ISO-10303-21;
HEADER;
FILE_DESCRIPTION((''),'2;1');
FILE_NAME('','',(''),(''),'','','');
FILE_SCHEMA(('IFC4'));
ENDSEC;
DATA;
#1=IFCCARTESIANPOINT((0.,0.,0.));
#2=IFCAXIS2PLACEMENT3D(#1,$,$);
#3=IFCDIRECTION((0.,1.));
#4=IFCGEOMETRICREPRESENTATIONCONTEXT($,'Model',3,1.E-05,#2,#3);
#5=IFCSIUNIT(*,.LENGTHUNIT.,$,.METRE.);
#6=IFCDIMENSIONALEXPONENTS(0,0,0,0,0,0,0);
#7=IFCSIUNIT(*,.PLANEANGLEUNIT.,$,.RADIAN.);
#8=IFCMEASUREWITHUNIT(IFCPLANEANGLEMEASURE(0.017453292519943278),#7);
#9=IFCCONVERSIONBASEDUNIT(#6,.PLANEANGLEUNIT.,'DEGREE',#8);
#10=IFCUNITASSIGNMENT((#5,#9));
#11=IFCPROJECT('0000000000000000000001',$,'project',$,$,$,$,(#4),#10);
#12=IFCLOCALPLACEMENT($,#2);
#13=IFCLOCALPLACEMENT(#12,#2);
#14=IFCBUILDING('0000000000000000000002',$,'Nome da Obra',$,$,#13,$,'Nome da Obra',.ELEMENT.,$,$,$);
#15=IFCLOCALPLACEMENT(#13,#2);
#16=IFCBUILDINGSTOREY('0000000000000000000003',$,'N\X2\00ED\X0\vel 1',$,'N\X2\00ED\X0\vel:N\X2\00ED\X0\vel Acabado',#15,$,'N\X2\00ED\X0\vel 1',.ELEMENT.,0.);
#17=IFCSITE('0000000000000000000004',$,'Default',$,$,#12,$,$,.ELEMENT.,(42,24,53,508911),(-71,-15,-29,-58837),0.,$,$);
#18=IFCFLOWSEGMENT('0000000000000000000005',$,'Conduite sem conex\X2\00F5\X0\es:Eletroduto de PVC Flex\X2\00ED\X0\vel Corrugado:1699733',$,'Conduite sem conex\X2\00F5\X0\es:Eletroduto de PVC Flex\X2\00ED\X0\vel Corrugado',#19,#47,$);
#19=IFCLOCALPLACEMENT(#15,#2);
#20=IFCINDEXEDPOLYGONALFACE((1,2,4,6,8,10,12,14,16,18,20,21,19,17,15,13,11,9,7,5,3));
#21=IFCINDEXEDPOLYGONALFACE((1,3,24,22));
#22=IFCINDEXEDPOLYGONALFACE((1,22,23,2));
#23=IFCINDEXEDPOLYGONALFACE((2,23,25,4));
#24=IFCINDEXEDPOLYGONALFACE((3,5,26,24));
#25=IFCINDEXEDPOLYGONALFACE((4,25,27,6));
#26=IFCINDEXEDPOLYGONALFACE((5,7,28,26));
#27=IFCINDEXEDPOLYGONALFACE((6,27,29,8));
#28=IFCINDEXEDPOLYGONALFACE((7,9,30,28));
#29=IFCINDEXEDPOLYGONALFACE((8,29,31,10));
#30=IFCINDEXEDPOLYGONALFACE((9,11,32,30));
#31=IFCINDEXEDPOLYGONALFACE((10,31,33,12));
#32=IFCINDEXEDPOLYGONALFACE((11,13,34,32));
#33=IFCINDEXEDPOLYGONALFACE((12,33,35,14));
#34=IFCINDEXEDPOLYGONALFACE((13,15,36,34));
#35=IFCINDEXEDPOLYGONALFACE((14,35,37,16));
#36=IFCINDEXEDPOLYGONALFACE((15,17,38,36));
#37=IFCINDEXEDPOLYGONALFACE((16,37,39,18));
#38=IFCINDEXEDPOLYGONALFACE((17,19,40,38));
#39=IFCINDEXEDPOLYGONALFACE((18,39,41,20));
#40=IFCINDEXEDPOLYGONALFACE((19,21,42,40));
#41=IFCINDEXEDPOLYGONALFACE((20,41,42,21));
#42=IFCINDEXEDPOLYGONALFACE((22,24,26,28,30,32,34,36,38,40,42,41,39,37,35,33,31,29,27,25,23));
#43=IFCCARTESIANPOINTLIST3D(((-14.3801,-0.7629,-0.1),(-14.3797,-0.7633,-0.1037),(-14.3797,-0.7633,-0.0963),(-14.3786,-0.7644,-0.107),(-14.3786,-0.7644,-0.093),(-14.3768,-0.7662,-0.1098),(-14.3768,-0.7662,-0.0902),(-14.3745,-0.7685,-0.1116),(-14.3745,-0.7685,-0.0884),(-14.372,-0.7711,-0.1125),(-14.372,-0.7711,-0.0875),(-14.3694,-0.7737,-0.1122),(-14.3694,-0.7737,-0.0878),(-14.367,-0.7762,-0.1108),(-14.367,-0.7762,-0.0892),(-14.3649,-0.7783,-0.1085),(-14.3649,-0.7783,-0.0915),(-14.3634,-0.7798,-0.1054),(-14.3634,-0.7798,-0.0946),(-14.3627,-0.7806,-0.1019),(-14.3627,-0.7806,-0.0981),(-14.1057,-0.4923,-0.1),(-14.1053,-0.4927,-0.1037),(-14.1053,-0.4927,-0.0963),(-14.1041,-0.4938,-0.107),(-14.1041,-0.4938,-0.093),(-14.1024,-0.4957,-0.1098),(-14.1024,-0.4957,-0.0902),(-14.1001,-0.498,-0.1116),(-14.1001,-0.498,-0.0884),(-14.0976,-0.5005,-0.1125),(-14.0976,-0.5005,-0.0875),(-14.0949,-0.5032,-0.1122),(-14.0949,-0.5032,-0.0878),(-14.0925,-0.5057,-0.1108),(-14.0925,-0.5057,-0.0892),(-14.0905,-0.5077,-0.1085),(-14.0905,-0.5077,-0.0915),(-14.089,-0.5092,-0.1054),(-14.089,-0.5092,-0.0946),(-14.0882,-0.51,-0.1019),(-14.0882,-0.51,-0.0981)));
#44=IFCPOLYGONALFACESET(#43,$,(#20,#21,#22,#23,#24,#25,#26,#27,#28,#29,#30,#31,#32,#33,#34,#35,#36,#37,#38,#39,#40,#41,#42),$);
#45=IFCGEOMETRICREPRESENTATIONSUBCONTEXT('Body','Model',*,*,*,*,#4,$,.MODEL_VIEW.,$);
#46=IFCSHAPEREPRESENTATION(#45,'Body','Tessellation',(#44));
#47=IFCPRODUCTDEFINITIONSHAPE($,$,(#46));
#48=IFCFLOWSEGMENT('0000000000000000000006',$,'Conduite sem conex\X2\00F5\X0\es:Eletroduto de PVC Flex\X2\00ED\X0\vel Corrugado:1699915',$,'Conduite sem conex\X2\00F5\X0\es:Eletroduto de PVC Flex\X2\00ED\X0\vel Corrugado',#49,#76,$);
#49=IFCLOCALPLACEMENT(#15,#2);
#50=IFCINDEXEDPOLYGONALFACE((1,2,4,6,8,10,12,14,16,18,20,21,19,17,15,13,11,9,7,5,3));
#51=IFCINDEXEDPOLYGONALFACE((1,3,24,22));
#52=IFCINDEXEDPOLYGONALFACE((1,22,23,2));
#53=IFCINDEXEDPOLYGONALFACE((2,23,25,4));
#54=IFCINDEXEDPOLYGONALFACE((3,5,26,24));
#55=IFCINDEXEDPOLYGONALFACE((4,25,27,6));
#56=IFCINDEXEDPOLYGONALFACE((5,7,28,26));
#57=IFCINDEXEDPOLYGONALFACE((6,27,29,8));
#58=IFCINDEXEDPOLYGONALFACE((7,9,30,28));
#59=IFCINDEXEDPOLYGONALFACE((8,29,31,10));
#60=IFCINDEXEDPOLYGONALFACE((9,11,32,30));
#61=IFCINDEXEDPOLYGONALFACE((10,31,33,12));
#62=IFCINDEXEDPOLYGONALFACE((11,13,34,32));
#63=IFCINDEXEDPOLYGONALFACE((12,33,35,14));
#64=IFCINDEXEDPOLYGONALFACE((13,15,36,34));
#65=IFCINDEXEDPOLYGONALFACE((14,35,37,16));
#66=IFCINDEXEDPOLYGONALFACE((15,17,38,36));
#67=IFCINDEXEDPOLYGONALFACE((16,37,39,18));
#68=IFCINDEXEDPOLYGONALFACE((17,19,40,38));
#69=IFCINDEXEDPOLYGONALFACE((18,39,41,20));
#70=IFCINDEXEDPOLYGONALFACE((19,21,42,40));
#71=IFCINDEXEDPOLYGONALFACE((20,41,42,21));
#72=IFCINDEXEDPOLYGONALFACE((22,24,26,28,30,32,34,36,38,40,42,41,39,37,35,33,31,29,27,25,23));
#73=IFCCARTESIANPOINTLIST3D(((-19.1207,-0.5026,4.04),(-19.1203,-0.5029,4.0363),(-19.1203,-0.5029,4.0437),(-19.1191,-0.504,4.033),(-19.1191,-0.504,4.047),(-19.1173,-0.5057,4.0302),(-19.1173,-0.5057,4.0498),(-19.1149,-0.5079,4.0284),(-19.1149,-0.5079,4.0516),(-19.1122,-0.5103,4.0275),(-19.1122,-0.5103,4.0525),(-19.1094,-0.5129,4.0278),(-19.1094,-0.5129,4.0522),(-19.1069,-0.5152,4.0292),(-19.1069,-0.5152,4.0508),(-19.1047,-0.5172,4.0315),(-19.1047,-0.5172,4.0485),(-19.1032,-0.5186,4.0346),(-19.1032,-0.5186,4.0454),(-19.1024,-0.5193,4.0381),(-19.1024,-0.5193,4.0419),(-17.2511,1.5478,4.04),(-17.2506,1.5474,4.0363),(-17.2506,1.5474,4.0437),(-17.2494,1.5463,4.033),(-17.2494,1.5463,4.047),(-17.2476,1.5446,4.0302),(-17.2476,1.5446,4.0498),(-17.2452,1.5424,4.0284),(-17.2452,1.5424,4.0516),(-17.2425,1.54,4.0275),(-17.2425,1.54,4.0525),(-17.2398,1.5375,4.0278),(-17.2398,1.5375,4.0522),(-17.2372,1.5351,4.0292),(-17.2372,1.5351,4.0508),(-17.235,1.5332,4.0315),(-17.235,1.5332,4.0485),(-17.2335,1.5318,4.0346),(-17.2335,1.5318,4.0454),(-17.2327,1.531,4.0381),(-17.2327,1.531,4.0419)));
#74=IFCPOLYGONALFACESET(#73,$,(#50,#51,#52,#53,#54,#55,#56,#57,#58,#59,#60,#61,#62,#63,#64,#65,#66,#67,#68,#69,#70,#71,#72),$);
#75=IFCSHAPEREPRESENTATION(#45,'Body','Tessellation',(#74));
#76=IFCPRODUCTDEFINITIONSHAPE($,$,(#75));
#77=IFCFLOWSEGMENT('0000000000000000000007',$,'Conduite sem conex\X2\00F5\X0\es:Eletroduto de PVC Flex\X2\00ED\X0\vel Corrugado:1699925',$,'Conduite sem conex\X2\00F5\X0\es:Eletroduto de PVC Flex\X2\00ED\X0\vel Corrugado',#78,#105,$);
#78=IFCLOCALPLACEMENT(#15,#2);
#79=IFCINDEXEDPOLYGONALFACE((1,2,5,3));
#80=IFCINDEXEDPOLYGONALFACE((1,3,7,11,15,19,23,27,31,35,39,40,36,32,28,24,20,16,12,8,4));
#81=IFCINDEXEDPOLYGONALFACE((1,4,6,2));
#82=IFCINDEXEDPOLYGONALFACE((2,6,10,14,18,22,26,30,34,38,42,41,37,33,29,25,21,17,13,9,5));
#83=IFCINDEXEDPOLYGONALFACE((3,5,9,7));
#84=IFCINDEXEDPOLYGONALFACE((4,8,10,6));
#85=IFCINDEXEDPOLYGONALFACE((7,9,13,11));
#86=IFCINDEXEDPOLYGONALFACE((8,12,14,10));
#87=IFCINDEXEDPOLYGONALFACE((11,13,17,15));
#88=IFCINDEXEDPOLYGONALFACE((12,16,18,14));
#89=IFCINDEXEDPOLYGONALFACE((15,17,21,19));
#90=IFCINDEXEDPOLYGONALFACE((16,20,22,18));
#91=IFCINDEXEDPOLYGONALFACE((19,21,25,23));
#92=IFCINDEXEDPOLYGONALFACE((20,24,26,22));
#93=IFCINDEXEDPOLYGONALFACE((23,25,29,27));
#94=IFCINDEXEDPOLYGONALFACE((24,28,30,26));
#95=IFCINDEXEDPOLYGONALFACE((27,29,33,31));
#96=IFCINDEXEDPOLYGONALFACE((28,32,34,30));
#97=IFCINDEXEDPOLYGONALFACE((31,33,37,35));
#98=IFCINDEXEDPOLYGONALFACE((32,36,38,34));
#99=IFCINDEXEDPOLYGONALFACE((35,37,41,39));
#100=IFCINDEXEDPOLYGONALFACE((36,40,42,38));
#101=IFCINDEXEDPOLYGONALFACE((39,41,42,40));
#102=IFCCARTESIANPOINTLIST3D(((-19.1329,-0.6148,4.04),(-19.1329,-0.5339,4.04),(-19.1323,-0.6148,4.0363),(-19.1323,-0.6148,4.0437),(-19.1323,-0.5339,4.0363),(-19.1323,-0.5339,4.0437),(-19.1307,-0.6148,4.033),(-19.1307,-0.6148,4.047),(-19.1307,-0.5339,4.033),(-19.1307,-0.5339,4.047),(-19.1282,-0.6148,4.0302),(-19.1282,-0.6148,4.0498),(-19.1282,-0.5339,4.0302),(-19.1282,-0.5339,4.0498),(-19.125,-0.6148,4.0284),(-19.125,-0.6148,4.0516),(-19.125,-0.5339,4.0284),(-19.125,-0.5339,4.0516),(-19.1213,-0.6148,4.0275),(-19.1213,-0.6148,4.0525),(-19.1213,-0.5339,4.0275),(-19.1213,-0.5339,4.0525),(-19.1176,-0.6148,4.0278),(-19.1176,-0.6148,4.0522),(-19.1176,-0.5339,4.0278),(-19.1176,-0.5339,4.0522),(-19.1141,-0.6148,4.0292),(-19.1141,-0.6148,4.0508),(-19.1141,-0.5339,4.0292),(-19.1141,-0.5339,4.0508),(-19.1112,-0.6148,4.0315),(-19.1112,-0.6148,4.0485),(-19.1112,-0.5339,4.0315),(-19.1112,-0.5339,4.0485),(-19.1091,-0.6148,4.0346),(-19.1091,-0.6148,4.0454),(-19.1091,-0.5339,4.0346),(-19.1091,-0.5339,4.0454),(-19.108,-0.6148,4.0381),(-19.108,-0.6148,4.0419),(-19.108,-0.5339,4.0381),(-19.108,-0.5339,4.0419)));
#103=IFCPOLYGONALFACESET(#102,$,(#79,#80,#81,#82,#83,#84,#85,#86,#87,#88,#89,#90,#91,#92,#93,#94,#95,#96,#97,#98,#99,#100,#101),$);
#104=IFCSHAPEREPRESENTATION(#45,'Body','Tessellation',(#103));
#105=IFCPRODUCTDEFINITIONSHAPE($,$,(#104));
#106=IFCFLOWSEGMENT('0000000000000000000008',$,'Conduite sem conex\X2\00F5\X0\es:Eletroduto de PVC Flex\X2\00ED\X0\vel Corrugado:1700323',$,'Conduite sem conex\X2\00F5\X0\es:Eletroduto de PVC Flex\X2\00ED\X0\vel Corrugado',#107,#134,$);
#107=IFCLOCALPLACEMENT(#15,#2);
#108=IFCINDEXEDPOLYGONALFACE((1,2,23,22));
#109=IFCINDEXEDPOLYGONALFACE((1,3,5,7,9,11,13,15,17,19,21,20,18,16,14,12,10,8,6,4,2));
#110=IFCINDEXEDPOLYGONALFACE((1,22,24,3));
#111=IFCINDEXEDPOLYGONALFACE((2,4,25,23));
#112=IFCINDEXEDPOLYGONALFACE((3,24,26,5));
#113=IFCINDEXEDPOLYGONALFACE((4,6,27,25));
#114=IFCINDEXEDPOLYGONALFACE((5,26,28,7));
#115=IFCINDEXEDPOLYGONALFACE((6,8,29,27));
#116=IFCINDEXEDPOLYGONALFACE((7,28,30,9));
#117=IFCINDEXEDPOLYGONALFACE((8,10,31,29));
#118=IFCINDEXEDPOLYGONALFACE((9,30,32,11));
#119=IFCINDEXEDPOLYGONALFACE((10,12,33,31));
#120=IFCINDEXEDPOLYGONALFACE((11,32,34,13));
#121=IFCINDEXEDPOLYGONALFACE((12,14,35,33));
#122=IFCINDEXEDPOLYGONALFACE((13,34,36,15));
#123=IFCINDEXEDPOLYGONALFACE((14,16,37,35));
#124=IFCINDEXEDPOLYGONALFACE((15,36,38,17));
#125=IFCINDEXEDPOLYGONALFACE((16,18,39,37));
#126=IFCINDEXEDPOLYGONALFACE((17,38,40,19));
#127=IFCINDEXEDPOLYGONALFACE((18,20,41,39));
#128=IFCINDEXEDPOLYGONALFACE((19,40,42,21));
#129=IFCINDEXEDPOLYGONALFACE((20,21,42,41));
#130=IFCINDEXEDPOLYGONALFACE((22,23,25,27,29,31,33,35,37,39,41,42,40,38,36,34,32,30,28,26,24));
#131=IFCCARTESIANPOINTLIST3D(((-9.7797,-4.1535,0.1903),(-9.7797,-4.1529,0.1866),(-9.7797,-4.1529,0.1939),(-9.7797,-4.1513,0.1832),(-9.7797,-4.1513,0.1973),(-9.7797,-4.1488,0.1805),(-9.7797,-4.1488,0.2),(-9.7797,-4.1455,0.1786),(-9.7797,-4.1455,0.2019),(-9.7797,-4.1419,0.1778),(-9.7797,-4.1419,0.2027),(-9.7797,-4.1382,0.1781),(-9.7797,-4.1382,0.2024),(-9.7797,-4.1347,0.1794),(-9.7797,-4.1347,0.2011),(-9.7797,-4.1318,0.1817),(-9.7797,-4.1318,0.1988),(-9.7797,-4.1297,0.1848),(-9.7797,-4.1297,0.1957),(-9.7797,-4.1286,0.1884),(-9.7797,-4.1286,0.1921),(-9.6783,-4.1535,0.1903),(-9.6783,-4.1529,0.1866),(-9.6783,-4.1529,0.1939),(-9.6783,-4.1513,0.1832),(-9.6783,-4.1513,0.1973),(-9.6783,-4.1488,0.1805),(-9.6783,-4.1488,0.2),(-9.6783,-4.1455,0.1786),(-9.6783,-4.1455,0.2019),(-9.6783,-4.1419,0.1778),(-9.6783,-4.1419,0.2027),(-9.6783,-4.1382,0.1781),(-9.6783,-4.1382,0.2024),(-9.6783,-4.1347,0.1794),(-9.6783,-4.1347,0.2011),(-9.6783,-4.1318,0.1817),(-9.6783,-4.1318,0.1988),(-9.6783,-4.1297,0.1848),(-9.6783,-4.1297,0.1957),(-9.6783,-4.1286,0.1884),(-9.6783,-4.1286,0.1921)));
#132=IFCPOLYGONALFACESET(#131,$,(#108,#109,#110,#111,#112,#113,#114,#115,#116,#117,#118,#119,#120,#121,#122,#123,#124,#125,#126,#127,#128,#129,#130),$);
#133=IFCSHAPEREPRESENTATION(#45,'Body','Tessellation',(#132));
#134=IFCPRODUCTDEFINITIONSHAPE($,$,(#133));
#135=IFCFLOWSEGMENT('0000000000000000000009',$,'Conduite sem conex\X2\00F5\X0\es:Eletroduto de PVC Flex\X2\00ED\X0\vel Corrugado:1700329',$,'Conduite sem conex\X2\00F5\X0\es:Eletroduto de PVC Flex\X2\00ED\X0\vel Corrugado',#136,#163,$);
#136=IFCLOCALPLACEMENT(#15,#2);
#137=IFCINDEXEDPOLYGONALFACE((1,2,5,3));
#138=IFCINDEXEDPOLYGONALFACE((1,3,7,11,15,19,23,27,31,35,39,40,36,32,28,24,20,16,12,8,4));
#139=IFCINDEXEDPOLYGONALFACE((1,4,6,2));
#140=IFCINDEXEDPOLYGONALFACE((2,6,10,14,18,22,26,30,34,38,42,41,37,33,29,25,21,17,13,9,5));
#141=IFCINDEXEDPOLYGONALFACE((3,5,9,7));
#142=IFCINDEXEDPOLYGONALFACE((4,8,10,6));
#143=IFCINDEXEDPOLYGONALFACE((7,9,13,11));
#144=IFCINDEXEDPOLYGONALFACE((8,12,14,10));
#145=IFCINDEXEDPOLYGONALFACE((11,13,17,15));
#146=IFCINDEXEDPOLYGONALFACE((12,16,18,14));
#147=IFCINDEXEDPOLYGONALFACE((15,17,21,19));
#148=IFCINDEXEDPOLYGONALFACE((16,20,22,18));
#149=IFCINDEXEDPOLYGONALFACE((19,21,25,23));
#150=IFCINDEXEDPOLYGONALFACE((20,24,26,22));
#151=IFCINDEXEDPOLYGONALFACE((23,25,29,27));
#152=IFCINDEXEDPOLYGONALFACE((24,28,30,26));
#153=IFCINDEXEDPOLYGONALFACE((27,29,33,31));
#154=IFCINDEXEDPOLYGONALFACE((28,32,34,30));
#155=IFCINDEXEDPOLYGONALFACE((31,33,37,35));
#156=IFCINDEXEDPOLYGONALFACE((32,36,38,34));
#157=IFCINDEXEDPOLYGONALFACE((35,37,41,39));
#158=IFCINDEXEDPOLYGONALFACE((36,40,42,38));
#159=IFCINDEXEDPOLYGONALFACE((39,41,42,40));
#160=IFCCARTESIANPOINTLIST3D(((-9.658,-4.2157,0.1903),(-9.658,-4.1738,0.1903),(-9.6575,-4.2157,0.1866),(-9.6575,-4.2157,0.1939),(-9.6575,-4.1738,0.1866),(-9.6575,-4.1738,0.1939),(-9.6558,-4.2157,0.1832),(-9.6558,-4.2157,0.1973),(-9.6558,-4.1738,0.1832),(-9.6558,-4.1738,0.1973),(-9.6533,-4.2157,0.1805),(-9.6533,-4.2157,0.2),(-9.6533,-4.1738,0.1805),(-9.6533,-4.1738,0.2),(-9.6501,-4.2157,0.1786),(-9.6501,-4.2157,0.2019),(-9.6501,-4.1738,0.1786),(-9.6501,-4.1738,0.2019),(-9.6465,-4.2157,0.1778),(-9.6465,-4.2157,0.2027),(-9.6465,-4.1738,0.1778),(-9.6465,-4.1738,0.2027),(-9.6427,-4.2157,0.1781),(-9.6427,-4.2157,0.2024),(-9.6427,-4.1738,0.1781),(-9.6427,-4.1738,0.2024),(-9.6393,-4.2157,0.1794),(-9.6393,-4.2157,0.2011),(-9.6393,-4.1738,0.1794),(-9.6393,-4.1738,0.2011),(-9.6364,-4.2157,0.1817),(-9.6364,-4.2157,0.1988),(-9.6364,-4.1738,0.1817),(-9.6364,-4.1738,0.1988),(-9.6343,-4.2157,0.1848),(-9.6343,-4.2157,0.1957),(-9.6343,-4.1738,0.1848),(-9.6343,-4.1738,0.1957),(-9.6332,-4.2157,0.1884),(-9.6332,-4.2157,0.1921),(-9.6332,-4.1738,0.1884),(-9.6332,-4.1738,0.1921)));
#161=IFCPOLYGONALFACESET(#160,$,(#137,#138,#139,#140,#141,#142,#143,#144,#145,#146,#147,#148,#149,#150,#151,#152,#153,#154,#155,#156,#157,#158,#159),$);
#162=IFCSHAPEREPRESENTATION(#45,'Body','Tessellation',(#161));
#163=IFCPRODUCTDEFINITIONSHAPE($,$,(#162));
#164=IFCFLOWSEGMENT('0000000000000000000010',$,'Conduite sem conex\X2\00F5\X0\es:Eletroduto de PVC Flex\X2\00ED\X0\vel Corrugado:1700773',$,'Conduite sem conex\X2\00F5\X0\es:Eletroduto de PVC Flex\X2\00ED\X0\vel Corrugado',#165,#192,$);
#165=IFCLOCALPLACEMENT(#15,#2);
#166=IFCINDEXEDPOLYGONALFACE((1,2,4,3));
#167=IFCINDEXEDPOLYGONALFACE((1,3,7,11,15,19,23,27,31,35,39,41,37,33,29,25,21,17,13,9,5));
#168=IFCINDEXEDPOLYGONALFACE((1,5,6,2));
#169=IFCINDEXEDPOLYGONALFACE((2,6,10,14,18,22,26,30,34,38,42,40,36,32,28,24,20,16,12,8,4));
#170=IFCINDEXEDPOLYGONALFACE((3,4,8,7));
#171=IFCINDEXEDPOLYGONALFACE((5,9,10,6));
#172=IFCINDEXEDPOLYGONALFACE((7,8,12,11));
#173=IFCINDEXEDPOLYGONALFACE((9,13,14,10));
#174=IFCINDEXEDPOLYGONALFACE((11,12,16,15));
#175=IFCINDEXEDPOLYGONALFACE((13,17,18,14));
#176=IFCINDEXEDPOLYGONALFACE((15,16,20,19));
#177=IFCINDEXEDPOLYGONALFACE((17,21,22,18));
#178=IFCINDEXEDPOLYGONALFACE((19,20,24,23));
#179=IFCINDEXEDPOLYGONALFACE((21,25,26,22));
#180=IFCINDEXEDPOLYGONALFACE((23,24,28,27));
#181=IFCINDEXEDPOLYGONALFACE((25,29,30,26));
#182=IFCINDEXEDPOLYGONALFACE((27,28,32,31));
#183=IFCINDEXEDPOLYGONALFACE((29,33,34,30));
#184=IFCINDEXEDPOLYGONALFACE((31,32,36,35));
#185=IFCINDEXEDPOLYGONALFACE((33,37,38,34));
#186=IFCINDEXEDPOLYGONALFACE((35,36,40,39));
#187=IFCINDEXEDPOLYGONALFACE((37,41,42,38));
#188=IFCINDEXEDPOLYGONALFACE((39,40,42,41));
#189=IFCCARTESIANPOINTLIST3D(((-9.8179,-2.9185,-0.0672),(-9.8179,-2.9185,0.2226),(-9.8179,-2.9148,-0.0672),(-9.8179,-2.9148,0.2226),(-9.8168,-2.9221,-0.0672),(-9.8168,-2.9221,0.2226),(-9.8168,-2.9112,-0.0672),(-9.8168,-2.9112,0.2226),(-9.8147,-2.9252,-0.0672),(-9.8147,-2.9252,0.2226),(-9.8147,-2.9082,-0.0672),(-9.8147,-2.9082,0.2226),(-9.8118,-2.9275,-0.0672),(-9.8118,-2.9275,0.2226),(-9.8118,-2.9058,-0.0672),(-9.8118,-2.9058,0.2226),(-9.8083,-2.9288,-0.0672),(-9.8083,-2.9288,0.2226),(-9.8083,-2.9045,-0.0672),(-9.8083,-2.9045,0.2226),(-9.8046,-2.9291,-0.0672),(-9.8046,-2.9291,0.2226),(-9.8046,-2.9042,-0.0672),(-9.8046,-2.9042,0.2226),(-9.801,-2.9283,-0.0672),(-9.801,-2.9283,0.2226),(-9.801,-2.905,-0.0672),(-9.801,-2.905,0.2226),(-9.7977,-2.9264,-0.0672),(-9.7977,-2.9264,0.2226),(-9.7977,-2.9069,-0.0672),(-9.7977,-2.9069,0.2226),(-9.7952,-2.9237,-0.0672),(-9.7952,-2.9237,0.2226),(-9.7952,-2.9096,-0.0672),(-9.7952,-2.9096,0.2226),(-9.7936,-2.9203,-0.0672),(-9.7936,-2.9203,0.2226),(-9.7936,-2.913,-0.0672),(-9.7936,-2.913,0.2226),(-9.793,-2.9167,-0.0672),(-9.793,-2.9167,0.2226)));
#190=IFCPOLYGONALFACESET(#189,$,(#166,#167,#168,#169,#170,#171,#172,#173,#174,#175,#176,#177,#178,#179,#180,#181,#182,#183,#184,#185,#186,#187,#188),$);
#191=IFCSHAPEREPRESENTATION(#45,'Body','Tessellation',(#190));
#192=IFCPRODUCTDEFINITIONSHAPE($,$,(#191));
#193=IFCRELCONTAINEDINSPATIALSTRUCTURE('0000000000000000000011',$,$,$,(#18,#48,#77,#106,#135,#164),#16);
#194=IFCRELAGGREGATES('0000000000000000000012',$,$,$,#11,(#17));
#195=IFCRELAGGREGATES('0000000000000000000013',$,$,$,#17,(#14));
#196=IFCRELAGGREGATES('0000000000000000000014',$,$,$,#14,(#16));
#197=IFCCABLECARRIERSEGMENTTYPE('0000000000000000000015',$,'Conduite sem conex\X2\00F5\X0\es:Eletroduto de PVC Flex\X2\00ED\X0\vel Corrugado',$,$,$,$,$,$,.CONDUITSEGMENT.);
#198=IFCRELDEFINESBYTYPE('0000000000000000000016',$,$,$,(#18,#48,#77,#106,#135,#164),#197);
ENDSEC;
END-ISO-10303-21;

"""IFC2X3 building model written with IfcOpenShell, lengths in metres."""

from ifc_helpers import new_model, entity, si_unit, converted_unit, direction, frame, frame_2d, origin, origin_2d_with_axis, place, context, subcontext, project, spatial, circle, extrude, type_object, element, save


model = new_model("IFC2X3")

# Units and contexts
model_context = context("Model", 3, precision=1e-05, world=origin(), true_north=direction((0.0, 1.0)))
body_context = subcontext(model_context, "Body", "Model", "MODEL_VIEW")
ifc_project = project(units=[si_unit("LENGTHUNIT", "METRE"), converted_unit("PLANEANGLEUNIT", "DEGREE", entity("IfcPlaneAngleMeasure", 0.017453292519943278), si_unit("PLANEANGLEUNIT", "RADIAN"), dimensions=[0, 0, 0, 0, 0, 0, 0])], contexts=[model_context])

# Site, building, storey
site_placement = place(None, origin())
site = spatial("IfcSite", under=ifc_project, at=site_placement, Name="Default", CompositionType="ELEMENT", RefLatitude=(42, 24, 53, 508911), RefLongitude=(-71, -15, -29, -58837), RefElevation=0.0)
building_placement = place(site_placement, origin())
building = spatial("IfcBuilding", under=site, at=building_placement, Name="Nome da Obra", LongName="Nome da Obra", CompositionType="ELEMENT")
storey_placement = place(building_placement, origin())
storey = spatial("IfcBuildingStorey", under=building, at=storey_placement, Name="Nível 1", ObjectType="Nível:Nível Acabado", LongName="Nível 1", CompositionType="ELEMENT", Elevation=0.0)

# Flow segments
cable_carrier_segment_type = type_object("IfcCableCarrierSegmentType", Name="Conduite sem conexões:Eletroduto de PVC Flexível Corrugado", PredefinedType="CONDUITSEGMENT")
flow_segment_1_placement = place(storey_placement, origin())
element("IfcFlowSegment", 1, at=flow_segment_1_placement, inside=storey, type_object=cable_carrier_segment_type, Name="Conduite sem conexões:Eletroduto de PVC Flexível Corrugado:1699733", ObjectType="Conduite sem conexões:Eletroduto de PVC Flexível Corrugado", context=body_context, shape_type="SweptSolid", body=[
    extrude(circle(Radius=0.0125, at=frame_2d((0.0, 0.0), x_axis=(1.0, 0.0))), frame((-14.3713, -0.7718, -0.1), z_axis=(0.712135, 0.702042, 0.0), x_axis=(-0.702042, 0.712135, 0.0)), (0.0, 0.0, 1.0), 0.3854),
])
flow_segment_2_placement = place(storey_placement, origin())
element("IfcFlowSegment", 2, at=flow_segment_2_placement, inside=storey, type_object=cable_carrier_segment_type, Name="Conduite sem conexões:Eletroduto de PVC Flexível Corrugado:1699915", ObjectType="Conduite sem conexões:Eletroduto de PVC Flexível Corrugado", context=body_context, shape_type="SweptSolid", body=[
    extrude(circle(Radius=0.0125, at=origin_2d_with_axis()), frame((-19.1115, -0.511, 4.04), z_axis=(0.673804, 0.73891, 0.0), x_axis=(-0.73891, 0.673804, 0.0)), (0.0, 0.0, 1.0), 2.7748),
])
flow_segment_3_placement = place(storey_placement, origin())
element("IfcFlowSegment", 3, at=flow_segment_3_placement, inside=storey, type_object=cable_carrier_segment_type, Name="Conduite sem conexões:Eletroduto de PVC Flexível Corrugado:1699925", ObjectType="Conduite sem conexões:Eletroduto de PVC Flexível Corrugado", context=body_context, shape_type="SweptSolid", body=[
    extrude(circle(Radius=0.0125, at=frame_2d((0.0, 0.0), x_axis=(1.0, 0.0))), frame((-19.1204, -0.6148, 4.04), z_axis=(0.0, 1.0, 0.0), x_axis=(-1.0, 0.0, 0.0)), (0.0, 0.0, 1.0), 0.0809),
])
flow_segment_4_placement = place(storey_placement, origin())
element("IfcFlowSegment", 4, at=flow_segment_4_placement, inside=storey, type_object=cable_carrier_segment_type, Name="Conduite sem conexões:Eletroduto de PVC Flexível Corrugado:1700323", ObjectType="Conduite sem conexões:Eletroduto de PVC Flexível Corrugado", context=body_context, shape_type="SweptSolid", body=[
    extrude(circle(Radius=0.0125, at=origin_2d_with_axis()), frame((-9.7797, -4.141, 0.1903), z_axis=(1.0, 0.0, 0.0), x_axis=(0.0, -1.0, 0.0)), (0.0, 0.0, 1.0), 0.1014),
])
flow_segment_5_placement = place(storey_placement, origin())
element("IfcFlowSegment", 5, at=flow_segment_5_placement, inside=storey, type_object=cable_carrier_segment_type, Name="Conduite sem conexões:Eletroduto de PVC Flexível Corrugado:1700329", ObjectType="Conduite sem conexões:Eletroduto de PVC Flexível Corrugado", context=body_context, shape_type="SweptSolid", body=[
    extrude(circle(Radius=0.0125, at=frame_2d((0.0, 0.0), x_axis=(1.0, 0.0))), frame((-9.6455, -4.2157, 0.1903), z_axis=(0.0, 1.0, 0.0), x_axis=(-1.0, 0.0, 0.0)), (0.0, 0.0, 1.0), 0.0419),
])
flow_segment_6_placement = place(storey_placement, origin())
element("IfcFlowSegment", 6, at=flow_segment_6_placement, inside=storey, type_object=cable_carrier_segment_type, Name="Conduite sem conexões:Eletroduto de PVC Flexível Corrugado:1700773", ObjectType="Conduite sem conexões:Eletroduto de PVC Flexível Corrugado", context=body_context, shape_type="SweptSolid", body=[
    extrude(circle(Radius=0.0125, at=frame_2d((0.0, 0.0), x_axis=(1.0, 0.0))), frame((-9.8055, -2.9167, -0.0672)), (0.0, 0.0, 1.0), 0.2898),
])

save(model, "model.ifc")
